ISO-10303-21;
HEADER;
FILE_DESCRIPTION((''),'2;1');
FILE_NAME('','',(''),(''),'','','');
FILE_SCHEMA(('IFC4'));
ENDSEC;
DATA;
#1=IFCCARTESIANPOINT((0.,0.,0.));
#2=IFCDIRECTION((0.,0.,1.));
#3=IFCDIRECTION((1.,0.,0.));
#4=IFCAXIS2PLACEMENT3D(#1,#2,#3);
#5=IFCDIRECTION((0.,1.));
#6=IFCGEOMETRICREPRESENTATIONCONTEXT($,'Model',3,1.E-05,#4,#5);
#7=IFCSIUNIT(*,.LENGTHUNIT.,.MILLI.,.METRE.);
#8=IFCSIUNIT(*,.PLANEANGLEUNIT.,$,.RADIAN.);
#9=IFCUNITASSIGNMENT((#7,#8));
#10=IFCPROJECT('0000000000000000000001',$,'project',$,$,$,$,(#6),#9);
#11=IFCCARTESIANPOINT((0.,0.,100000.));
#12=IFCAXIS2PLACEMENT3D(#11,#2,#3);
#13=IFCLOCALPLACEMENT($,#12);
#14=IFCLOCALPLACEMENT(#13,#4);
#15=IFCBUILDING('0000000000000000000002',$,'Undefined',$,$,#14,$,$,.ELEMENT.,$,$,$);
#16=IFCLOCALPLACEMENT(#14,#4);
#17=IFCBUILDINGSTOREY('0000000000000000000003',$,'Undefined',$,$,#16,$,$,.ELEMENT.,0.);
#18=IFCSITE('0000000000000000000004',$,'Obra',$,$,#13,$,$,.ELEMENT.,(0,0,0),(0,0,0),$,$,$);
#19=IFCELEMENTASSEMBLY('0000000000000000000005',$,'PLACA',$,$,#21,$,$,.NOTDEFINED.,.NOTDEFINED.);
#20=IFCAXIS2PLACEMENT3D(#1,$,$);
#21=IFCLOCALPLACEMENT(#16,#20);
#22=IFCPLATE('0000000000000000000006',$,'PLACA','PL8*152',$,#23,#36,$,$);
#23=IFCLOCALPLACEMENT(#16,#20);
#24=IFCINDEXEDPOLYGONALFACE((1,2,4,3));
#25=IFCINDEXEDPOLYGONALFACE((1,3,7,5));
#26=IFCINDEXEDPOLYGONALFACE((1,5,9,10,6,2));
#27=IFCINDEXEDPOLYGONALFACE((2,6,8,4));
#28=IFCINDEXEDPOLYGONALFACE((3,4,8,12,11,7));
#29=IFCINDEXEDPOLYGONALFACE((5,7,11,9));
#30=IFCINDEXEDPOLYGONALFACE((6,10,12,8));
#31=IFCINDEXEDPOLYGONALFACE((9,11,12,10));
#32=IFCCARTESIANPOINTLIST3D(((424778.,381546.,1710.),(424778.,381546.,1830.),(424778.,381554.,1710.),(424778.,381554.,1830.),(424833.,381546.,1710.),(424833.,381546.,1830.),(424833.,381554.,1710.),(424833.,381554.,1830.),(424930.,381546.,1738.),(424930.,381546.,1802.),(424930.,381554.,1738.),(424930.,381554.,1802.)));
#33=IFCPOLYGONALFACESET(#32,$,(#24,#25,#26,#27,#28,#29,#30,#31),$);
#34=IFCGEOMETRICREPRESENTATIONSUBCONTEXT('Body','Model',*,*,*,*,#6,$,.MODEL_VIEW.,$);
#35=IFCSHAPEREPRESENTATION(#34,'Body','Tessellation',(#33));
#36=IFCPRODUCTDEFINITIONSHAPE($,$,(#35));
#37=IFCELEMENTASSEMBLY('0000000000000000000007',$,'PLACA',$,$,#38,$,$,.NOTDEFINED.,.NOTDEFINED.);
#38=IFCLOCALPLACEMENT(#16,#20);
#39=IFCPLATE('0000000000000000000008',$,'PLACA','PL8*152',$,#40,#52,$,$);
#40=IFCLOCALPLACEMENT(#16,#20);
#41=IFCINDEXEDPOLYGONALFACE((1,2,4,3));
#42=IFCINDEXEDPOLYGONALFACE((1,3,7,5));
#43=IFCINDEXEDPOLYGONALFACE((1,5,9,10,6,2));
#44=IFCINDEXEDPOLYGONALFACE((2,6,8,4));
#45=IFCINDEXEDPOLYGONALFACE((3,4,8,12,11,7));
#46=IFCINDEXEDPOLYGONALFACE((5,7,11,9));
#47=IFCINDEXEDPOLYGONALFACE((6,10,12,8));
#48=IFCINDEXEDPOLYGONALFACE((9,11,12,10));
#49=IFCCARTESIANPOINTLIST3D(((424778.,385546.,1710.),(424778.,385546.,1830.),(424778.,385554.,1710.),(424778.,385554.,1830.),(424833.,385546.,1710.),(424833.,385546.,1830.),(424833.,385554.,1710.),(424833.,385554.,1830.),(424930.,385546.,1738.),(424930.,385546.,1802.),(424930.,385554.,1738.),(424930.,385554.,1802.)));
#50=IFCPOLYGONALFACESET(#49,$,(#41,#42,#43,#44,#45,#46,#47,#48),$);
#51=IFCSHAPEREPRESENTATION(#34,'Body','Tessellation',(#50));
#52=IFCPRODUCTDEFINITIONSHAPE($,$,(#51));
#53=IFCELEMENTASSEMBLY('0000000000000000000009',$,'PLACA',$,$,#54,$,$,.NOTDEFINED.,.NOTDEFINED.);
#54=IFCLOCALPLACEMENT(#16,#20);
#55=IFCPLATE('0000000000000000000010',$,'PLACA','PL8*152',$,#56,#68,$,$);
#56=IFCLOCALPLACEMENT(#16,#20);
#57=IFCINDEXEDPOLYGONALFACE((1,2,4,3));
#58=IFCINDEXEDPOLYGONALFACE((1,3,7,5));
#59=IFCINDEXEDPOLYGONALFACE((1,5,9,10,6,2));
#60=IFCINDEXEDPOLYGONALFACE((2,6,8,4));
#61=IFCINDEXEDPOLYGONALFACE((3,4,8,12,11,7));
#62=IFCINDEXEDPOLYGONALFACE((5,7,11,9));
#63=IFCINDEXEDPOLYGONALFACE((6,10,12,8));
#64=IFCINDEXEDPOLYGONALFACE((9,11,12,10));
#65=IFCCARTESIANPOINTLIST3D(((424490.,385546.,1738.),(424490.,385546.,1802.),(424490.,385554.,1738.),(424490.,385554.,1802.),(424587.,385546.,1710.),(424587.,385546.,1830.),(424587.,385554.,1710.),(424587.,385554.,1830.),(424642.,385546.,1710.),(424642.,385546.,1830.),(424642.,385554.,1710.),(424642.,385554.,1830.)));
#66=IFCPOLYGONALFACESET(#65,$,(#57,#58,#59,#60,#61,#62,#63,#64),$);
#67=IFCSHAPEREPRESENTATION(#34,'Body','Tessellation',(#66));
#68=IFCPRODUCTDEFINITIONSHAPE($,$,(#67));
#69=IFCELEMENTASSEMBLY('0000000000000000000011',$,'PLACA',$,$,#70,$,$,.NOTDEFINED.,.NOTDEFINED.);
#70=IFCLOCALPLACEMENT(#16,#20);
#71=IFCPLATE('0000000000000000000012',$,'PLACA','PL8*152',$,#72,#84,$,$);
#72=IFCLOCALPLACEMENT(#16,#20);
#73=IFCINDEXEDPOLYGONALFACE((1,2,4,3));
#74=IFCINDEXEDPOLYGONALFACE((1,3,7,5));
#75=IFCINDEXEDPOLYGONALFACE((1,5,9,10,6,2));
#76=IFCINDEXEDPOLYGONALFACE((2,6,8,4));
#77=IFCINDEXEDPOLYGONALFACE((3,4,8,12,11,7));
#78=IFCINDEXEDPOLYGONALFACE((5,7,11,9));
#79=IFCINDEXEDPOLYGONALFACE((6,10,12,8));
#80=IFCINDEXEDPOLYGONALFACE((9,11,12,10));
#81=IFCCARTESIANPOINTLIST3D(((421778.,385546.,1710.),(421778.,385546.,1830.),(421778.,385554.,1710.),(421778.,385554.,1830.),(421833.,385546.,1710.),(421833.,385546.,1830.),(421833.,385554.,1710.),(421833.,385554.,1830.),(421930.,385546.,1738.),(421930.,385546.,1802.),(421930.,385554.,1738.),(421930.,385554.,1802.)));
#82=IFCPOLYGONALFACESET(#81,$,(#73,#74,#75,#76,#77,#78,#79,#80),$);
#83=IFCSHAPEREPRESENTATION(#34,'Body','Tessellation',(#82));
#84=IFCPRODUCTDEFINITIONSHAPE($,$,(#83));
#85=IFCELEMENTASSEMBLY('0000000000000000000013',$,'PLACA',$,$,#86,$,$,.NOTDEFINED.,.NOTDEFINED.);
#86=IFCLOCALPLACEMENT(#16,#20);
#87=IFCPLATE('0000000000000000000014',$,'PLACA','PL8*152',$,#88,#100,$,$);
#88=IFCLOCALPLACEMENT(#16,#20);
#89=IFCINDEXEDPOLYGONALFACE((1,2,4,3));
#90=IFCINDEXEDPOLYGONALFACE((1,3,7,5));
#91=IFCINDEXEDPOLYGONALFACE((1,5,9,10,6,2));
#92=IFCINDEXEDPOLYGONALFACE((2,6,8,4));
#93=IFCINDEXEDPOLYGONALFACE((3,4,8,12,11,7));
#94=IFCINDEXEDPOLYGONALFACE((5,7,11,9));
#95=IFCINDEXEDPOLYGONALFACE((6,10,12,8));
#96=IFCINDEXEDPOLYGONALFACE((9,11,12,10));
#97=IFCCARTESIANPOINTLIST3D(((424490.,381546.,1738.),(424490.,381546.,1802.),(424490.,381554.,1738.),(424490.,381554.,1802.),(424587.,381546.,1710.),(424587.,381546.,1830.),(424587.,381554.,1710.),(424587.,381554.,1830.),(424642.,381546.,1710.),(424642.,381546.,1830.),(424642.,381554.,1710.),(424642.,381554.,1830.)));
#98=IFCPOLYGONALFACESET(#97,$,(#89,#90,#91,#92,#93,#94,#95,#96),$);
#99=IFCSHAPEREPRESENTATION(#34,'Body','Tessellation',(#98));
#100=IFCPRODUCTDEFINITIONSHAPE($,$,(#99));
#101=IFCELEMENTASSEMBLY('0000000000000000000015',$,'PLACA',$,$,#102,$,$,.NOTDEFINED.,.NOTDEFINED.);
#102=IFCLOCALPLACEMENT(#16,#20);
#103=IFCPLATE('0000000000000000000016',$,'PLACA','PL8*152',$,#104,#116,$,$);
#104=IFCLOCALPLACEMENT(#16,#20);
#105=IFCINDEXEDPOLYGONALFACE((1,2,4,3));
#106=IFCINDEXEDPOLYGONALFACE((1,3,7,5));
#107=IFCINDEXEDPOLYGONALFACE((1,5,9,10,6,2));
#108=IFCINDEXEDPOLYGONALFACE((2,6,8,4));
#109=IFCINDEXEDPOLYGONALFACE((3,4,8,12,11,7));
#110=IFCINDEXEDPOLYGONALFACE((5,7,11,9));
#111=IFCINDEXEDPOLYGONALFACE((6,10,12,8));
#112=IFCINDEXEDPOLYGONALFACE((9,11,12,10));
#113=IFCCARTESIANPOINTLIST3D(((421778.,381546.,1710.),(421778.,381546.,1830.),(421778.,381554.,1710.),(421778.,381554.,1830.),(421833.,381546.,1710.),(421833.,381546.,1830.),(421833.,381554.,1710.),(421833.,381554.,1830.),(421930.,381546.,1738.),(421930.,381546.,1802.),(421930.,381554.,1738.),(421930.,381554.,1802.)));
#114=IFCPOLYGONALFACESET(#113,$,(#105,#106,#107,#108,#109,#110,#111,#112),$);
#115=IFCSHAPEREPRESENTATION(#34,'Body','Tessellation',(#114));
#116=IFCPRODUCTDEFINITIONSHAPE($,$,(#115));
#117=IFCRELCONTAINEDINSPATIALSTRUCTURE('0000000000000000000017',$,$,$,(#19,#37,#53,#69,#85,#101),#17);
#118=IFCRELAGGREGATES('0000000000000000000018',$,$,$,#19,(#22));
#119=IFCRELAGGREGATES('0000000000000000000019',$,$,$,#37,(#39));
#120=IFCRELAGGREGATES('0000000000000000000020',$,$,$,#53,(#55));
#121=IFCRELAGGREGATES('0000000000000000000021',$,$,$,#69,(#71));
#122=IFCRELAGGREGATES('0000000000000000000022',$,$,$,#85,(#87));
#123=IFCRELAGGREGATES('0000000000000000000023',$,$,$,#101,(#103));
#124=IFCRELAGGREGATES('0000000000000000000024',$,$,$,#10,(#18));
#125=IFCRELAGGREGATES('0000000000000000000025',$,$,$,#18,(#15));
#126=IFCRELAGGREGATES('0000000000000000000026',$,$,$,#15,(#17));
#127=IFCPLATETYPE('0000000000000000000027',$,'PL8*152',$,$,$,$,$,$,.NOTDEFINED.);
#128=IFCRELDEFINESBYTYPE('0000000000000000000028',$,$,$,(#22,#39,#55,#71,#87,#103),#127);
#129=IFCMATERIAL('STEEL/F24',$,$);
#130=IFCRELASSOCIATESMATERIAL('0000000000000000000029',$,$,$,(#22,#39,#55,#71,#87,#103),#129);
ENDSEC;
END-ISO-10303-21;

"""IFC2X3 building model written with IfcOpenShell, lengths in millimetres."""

from ifc_helpers import new_model, si_unit, direction, frame, origin_with_axes, place, context, subcontext, project, spatial, polyline, outline, extrude, material, type_object, element, aggregate, save


model = new_model("IFC2X3")

# Units and contexts
model_context = context("Model", 3, precision=1e-05, world=origin_with_axes(), true_north=direction((0.0, 1.0)))
body_context = subcontext(model_context, "Body", "Model", "MODEL_VIEW")
ifc_project = project(units=[si_unit("LENGTHUNIT", "METRE", prefix="MILLI"), si_unit("PLANEANGLEUNIT", "RADIAN")], contexts=[model_context])

# Site, building, storey
site_placement = place(None, frame((0.0, 0.0, 100000.0), z_axis=(0.0, 0.0, 1.0), x_axis=(1.0, 0.0, 0.0)))
site = spatial("IfcSite", under=ifc_project, at=site_placement, Name="Obra", CompositionType="ELEMENT", RefLatitude=(0, 0, 0), RefLongitude=(0, 0, 0))
building_placement = place(site_placement, origin_with_axes())
building = spatial("IfcBuilding", under=site, at=building_placement, Name="Undefined", CompositionType="ELEMENT")
storey_placement = place(building_placement, origin_with_axes())
storey = spatial("IfcBuildingStorey", under=building, at=storey_placement, Name="Undefined", CompositionType="ELEMENT", Elevation=0.0)

# Shared definitions
ifc_material_1 = material(Name="STEEL/F24")

# Element assemblies, plates
plate_type_1 = type_object("IfcPlateType", Name="PL8*152", PredefinedType="NOTDEFINED")
assembly_1_placement = place(storey_placement, origin_with_axes())
assembly_1 = element("IfcElementAssembly", 1, at=assembly_1_placement, inside=storey, Name="PLACA", AssemblyPlace="NOTDEFINED", PredefinedType="NOTDEFINED")
plate_1_placement = place(assembly_1_placement, frame((424833.0, 381550.0, 1830.0), z_axis=(0.0, -1.0, 0.0), x_axis=(-1.0, 0.0, 0.0)))
plate_1 = element("IfcPlate", 2, at=plate_1_placement, type_object=plate_type_1, material=ifc_material_1, Name="PLACA", Description="PL8*152", context=body_context, shape_type="SweptSolid", body=[
    extrude(outline(polyline([(0.0, 0.0), (55.0, 0.0), (55.0, 120.0), (0.0, 120.0), (-97.0, 92.0), (-97.0, 28.0), (0.0, 0.0)])), frame((0.0, 0.0, -4.0), z_axis=(0.0, 0.0, 1.0), x_axis=(1.0, 0.0, 0.0)), (0.0, 0.0, 1.0), 8.0),
])
aggregate(assembly_1, [plate_1])
assembly_2_placement = place(storey_placement, origin_with_axes())
assembly_2 = element("IfcElementAssembly", 3, at=assembly_2_placement, inside=storey, Name="PLACA", AssemblyPlace="NOTDEFINED", PredefinedType="NOTDEFINED")
plate_2_placement = place(assembly_2_placement, frame((424833.0, 385550.0, 1830.0), z_axis=(0.0, -1.0, 0.0), x_axis=(-1.0, 0.0, 0.0)))
plate_2 = element("IfcPlate", 4, at=plate_2_placement, type_object=plate_type_1, material=ifc_material_1, Name="PLACA", Description="PL8*152", context=body_context, shape_type="SweptSolid", body=[
    extrude(outline(polyline([(0.0, 0.0), (55.0, 0.0), (55.0, 120.0), (0.0, 120.0), (-97.0, 92.0), (-97.0, 28.0), (0.0, 0.0)])), frame((0.0, 0.0, -4.0), z_axis=(0.0, 0.0, 1.0), x_axis=(1.0, 0.0, 0.0)), (0.0, 0.0, 1.0), 8.0),
])
aggregate(assembly_2, [plate_2])
assembly_3_placement = place(storey_placement, origin_with_axes())
assembly_3 = element("IfcElementAssembly", 5, at=assembly_3_placement, inside=storey, Name="PLACA", AssemblyPlace="NOTDEFINED", PredefinedType="NOTDEFINED")
plate_3_placement = place(assembly_3_placement, frame((424587.0, 385550.0, 1830.0), z_axis=(0.0, 1.0, 0.0), x_axis=(1.0, 0.0, 0.0)))
plate_3 = element("IfcPlate", 6, at=plate_3_placement, type_object=plate_type_1, material=ifc_material_1, Name="PLACA", Description="PL8*152", context=body_context, shape_type="SweptSolid", body=[
    extrude(outline(polyline([(0.0, 0.0), (55.0, 0.0), (55.0, 120.0), (0.0, 120.0), (-97.0, 92.0), (-97.0, 28.0), (0.0, 0.0)])), frame((0.0, 0.0, -4.0), z_axis=(0.0, 0.0, 1.0), x_axis=(1.0, 0.0, 0.0)), (0.0, 0.0, 1.0), 8.0),
])
aggregate(assembly_3, [plate_3])
assembly_4_placement = place(storey_placement, origin_with_axes())
assembly_4 = element("IfcElementAssembly", 7, at=assembly_4_placement, inside=storey, Name="PLACA", AssemblyPlace="NOTDEFINED", PredefinedType="NOTDEFINED")
plate_4_placement = place(assembly_4_placement, frame((421833.0, 385550.0, 1830.0), z_axis=(0.0, -1.0, 0.0), x_axis=(-1.0, 0.0, 0.0)))
plate_4 = element("IfcPlate", 8, at=plate_4_placement, type_object=plate_type_1, material=ifc_material_1, Name="PLACA", Description="PL8*152", context=body_context, shape_type="SweptSolid", body=[
    extrude(outline(polyline([(0.0, 0.0), (55.0, 0.0), (55.0, 120.0), (0.0, 120.0), (-97.0, 92.0), (-97.0, 28.0), (0.0, 0.0)])), frame((0.0, 0.0, -4.0), z_axis=(0.0, 0.0, 1.0), x_axis=(1.0, 0.0, 0.0)), (0.0, 0.0, 1.0), 8.0),
])
aggregate(assembly_4, [plate_4])
assembly_5_placement = place(storey_placement, origin_with_axes())
assembly_5 = element("IfcElementAssembly", 9, at=assembly_5_placement, inside=storey, Name="PLACA", AssemblyPlace="NOTDEFINED", PredefinedType="NOTDEFINED")
plate_5_placement = place(assembly_5_placement, frame((424587.0, 381550.0, 1830.0), z_axis=(0.0, 1.0, 0.0), x_axis=(1.0, 0.0, 0.0)))
plate_5 = element("IfcPlate", 10, at=plate_5_placement, type_object=plate_type_1, material=ifc_material_1, Name="PLACA", Description="PL8*152", context=body_context, shape_type="SweptSolid", body=[
    extrude(outline(polyline([(0.0, 0.0), (55.0, 0.0), (55.0, 120.0), (0.0, 120.0), (-97.0, 92.0), (-97.0, 28.0), (0.0, 0.0)])), frame((0.0, 0.0, -4.0), z_axis=(0.0, 0.0, 1.0), x_axis=(1.0, 0.0, 0.0)), (0.0, 0.0, 1.0), 8.0),
])
aggregate(assembly_5, [plate_5])
assembly_6_placement = place(storey_placement, origin_with_axes())
assembly_6 = element("IfcElementAssembly", 11, at=assembly_6_placement, inside=storey, Name="PLACA", AssemblyPlace="NOTDEFINED", PredefinedType="NOTDEFINED")
plate_6_placement = place(assembly_6_placement, frame((421833.0, 381550.0, 1830.0), z_axis=(0.0, -1.0, 0.0), x_axis=(-1.0, 0.0, 0.0)))
plate_6 = element("IfcPlate", 12, at=plate_6_placement, type_object=plate_type_1, material=ifc_material_1, Name="PLACA", Description="PL8*152", context=body_context, shape_type="SweptSolid", body=[
    extrude(outline(polyline([(0.0, 0.0), (55.0, 0.0), (55.0, 120.0), (0.0, 120.0), (-97.0, 92.0), (-97.0, 28.0), (0.0, 0.0)])), frame((0.0, 0.0, -4.0), z_axis=(0.0, 0.0, 1.0), x_axis=(1.0, 0.0, 0.0)), (0.0, 0.0, 1.0), 8.0),
])
aggregate(assembly_6, [plate_6])

save(model, "model.ifc")
